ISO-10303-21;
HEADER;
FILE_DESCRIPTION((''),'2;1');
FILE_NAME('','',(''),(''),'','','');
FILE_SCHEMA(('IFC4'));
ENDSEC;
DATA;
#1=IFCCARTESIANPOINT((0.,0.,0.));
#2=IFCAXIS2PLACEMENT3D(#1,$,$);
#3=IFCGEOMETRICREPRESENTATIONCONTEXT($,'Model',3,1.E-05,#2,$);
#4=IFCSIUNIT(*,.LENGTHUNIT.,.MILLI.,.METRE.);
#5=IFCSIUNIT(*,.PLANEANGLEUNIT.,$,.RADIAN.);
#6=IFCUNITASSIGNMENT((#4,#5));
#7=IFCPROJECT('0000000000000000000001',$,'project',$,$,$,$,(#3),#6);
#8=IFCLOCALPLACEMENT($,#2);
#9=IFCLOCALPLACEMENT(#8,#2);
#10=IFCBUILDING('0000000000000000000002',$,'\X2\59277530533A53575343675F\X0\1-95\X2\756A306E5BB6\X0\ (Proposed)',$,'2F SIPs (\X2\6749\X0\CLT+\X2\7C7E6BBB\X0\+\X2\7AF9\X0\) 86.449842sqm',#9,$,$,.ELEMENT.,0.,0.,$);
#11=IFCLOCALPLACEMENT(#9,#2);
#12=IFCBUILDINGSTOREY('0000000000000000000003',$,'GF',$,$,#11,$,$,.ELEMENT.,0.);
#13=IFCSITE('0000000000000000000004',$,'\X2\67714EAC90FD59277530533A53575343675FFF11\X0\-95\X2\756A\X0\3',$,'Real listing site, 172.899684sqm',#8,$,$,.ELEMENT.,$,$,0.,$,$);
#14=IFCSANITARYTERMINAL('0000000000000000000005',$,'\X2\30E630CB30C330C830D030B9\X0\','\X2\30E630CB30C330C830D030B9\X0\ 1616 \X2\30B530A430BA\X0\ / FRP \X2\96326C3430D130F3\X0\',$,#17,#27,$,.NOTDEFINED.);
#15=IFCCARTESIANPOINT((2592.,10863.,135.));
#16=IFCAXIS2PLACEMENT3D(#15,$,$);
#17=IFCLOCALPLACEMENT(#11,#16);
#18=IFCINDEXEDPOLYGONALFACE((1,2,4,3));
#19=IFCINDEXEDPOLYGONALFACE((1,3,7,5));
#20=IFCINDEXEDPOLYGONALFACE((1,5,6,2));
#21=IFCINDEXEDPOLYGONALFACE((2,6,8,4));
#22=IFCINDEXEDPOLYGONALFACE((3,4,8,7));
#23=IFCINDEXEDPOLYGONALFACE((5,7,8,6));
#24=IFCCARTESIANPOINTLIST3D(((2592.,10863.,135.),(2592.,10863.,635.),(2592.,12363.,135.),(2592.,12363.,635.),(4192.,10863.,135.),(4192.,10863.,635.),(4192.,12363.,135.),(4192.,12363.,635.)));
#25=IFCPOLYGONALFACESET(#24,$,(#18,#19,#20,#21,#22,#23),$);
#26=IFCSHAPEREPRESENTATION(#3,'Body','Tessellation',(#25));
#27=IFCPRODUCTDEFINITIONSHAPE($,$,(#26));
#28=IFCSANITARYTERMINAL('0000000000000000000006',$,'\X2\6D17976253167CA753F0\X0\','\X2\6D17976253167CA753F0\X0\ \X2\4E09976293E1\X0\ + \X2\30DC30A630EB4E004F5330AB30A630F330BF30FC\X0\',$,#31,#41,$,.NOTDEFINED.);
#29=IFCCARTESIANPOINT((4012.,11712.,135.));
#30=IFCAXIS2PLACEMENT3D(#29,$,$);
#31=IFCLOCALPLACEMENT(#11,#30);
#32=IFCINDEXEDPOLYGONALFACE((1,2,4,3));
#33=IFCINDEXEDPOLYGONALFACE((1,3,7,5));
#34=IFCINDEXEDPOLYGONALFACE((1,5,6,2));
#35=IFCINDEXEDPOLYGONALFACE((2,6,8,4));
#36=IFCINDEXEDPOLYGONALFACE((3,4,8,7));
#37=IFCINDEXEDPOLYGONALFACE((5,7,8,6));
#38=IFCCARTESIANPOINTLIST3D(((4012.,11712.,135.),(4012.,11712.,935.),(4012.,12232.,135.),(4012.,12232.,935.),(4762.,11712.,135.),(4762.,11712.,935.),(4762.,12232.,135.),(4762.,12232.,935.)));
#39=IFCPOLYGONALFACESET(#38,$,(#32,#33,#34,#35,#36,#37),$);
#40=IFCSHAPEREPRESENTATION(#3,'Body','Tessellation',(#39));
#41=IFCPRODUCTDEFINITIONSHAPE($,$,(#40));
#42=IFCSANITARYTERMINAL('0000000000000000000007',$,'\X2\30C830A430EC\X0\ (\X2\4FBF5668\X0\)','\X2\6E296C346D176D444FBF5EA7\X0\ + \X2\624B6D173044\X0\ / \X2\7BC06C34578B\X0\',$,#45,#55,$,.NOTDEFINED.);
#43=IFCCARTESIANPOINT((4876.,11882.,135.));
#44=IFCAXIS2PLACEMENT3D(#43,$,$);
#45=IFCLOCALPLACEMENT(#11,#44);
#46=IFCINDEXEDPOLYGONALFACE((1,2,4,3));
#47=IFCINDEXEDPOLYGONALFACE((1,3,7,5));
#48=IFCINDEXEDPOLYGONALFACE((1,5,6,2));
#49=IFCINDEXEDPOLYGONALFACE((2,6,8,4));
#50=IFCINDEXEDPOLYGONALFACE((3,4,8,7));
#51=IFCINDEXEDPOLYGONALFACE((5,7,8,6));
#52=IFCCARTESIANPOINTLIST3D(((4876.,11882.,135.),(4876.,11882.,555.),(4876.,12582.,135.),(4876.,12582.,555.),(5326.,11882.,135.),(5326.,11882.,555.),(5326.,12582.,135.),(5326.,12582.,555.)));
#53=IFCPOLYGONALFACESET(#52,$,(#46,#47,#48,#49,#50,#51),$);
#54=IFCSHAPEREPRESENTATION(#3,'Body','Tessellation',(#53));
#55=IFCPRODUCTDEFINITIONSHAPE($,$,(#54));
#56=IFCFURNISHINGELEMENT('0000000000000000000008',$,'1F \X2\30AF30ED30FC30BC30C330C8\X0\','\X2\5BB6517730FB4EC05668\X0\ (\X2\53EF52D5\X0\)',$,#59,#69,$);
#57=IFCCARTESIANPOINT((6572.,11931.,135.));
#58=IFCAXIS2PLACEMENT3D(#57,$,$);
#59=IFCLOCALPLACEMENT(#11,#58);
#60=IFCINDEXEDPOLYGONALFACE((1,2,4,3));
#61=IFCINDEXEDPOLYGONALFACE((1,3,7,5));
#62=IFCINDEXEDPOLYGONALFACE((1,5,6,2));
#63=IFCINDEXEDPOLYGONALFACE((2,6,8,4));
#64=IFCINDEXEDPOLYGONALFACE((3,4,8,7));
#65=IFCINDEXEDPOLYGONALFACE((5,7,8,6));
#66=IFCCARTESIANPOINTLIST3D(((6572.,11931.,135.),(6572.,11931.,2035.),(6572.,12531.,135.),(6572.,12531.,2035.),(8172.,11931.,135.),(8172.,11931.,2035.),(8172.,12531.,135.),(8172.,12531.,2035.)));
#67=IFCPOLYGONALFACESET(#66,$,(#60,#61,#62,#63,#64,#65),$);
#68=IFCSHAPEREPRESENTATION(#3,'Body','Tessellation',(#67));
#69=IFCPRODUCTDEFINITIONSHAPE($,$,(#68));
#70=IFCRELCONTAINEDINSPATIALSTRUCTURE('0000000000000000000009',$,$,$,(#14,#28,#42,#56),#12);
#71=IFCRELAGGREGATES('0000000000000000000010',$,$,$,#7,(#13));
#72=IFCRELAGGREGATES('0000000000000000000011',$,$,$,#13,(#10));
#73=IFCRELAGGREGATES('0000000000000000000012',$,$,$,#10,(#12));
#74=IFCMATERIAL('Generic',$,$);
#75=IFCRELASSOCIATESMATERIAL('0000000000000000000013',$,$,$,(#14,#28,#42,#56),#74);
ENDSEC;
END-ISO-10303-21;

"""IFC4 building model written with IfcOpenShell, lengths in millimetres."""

from ifc_helpers import new_model, si_unit, frame, frame_2d, origin, place, context, project, spatial, rectangle, extrude, material, element, save


model = new_model("IFC4")

# Units and contexts
model_context = context("Model", 3, precision=1e-05, world=origin())
ifc_project = project(units=[si_unit("LENGTHUNIT", "METRE", prefix="MILLI"), si_unit("PLANEANGLEUNIT", "RADIAN")], contexts=[model_context])

# Site, building, storey
site_placement = place(None, origin())
site = spatial("IfcSite", under=ifc_project, at=site_placement, Name="東京都大田区南千束１-95番3", ObjectType="Real listing site, 172.899684sqm", CompositionType="ELEMENT", RefElevation=0.0)
building_placement = place(site_placement, origin())
building = spatial("IfcBuilding", under=site, at=building_placement, Name="大田区南千束1-95番の家 (Proposed)", ObjectType="2F SIPs (杉CLT+籾殻+竹) 86.449842sqm", CompositionType="ELEMENT", ElevationOfRefHeight=0.0, ElevationOfTerrain=0.0)
storey_placement = place(building_placement, origin())
storey = spatial("IfcBuildingStorey", under=building, at=storey_placement, Name="GF", CompositionType="ELEMENT", Elevation=0.0)

# Shared definitions
ifc_material_1 = material(Name="Generic")

# Sanitary terminals
sanitary_terminal_1_placement = place(storey_placement, frame((2592.0, 10863.0, 135.0)))
element("IfcSanitaryTerminal", 1, at=sanitary_terminal_1_placement, inside=storey, material=ifc_material_1, Name="ユニットバス", Description="ユニットバス 1616 サイズ / FRP 防水パン", PredefinedType="NOTDEFINED", context=model_context, shape_type="SweptSolid", body=[
    extrude(rectangle(XDim=1600.0, YDim=1500.0, at=frame_2d((800.0, 750.0))), frame((2592.0, 10863.0, 135.0)), (0.0, 0.0, 1.0), 500.0),
])
sanitary_terminal_2_placement = place(storey_placement, frame((4012.0, 11712.0, 135.0)))
element("IfcSanitaryTerminal", 2, at=sanitary_terminal_2_placement, inside=storey, material=ifc_material_1, Name="洗面化粧台", Description="洗面化粧台 三面鏡 + ボウル一体カウンター", PredefinedType="NOTDEFINED", context=model_context, shape_type="SweptSolid", body=[
    extrude(rectangle(XDim=750.0, YDim=520.0, at=frame_2d((375.0, 260.0))), frame((4012.0, 11712.0, 135.0)), (0.0, 0.0, 1.0), 800.0),
])
sanitary_terminal_3_placement = place(storey_placement, frame((4876.0, 11882.0, 135.0)))
element("IfcSanitaryTerminal", 3, at=sanitary_terminal_3_placement, inside=storey, material=ifc_material_1, Name="トイレ (便器)", Description="温水洗浄便座 + 手洗い / 節水型", PredefinedType="NOTDEFINED", context=model_context, shape_type="SweptSolid", body=[
    extrude(rectangle(XDim=450.0, YDim=700.0, at=frame_2d((225.0, 350.0))), frame((4876.0, 11882.0, 135.0)), (0.0, 0.0, 1.0), 420.0),
])

# Furnishing element
furnishing_placement = place(storey_placement, frame((6572.0, 11931.0, 135.0)))
element("IfcFurnishingElement", 4, at=furnishing_placement, inside=storey, material=ifc_material_1, Name="1F クローゼット", Description="家具・什器 (可動)", context=model_context, shape_type="SweptSolid", body=[
    extrude(rectangle(XDim=1600.0, YDim=600.0, at=frame_2d((800.0, 300.0))), frame((6572.0, 11931.0, 135.0)), (0.0, 0.0, 1.0), 1900.0),
])

save(model, "model.ifc")
